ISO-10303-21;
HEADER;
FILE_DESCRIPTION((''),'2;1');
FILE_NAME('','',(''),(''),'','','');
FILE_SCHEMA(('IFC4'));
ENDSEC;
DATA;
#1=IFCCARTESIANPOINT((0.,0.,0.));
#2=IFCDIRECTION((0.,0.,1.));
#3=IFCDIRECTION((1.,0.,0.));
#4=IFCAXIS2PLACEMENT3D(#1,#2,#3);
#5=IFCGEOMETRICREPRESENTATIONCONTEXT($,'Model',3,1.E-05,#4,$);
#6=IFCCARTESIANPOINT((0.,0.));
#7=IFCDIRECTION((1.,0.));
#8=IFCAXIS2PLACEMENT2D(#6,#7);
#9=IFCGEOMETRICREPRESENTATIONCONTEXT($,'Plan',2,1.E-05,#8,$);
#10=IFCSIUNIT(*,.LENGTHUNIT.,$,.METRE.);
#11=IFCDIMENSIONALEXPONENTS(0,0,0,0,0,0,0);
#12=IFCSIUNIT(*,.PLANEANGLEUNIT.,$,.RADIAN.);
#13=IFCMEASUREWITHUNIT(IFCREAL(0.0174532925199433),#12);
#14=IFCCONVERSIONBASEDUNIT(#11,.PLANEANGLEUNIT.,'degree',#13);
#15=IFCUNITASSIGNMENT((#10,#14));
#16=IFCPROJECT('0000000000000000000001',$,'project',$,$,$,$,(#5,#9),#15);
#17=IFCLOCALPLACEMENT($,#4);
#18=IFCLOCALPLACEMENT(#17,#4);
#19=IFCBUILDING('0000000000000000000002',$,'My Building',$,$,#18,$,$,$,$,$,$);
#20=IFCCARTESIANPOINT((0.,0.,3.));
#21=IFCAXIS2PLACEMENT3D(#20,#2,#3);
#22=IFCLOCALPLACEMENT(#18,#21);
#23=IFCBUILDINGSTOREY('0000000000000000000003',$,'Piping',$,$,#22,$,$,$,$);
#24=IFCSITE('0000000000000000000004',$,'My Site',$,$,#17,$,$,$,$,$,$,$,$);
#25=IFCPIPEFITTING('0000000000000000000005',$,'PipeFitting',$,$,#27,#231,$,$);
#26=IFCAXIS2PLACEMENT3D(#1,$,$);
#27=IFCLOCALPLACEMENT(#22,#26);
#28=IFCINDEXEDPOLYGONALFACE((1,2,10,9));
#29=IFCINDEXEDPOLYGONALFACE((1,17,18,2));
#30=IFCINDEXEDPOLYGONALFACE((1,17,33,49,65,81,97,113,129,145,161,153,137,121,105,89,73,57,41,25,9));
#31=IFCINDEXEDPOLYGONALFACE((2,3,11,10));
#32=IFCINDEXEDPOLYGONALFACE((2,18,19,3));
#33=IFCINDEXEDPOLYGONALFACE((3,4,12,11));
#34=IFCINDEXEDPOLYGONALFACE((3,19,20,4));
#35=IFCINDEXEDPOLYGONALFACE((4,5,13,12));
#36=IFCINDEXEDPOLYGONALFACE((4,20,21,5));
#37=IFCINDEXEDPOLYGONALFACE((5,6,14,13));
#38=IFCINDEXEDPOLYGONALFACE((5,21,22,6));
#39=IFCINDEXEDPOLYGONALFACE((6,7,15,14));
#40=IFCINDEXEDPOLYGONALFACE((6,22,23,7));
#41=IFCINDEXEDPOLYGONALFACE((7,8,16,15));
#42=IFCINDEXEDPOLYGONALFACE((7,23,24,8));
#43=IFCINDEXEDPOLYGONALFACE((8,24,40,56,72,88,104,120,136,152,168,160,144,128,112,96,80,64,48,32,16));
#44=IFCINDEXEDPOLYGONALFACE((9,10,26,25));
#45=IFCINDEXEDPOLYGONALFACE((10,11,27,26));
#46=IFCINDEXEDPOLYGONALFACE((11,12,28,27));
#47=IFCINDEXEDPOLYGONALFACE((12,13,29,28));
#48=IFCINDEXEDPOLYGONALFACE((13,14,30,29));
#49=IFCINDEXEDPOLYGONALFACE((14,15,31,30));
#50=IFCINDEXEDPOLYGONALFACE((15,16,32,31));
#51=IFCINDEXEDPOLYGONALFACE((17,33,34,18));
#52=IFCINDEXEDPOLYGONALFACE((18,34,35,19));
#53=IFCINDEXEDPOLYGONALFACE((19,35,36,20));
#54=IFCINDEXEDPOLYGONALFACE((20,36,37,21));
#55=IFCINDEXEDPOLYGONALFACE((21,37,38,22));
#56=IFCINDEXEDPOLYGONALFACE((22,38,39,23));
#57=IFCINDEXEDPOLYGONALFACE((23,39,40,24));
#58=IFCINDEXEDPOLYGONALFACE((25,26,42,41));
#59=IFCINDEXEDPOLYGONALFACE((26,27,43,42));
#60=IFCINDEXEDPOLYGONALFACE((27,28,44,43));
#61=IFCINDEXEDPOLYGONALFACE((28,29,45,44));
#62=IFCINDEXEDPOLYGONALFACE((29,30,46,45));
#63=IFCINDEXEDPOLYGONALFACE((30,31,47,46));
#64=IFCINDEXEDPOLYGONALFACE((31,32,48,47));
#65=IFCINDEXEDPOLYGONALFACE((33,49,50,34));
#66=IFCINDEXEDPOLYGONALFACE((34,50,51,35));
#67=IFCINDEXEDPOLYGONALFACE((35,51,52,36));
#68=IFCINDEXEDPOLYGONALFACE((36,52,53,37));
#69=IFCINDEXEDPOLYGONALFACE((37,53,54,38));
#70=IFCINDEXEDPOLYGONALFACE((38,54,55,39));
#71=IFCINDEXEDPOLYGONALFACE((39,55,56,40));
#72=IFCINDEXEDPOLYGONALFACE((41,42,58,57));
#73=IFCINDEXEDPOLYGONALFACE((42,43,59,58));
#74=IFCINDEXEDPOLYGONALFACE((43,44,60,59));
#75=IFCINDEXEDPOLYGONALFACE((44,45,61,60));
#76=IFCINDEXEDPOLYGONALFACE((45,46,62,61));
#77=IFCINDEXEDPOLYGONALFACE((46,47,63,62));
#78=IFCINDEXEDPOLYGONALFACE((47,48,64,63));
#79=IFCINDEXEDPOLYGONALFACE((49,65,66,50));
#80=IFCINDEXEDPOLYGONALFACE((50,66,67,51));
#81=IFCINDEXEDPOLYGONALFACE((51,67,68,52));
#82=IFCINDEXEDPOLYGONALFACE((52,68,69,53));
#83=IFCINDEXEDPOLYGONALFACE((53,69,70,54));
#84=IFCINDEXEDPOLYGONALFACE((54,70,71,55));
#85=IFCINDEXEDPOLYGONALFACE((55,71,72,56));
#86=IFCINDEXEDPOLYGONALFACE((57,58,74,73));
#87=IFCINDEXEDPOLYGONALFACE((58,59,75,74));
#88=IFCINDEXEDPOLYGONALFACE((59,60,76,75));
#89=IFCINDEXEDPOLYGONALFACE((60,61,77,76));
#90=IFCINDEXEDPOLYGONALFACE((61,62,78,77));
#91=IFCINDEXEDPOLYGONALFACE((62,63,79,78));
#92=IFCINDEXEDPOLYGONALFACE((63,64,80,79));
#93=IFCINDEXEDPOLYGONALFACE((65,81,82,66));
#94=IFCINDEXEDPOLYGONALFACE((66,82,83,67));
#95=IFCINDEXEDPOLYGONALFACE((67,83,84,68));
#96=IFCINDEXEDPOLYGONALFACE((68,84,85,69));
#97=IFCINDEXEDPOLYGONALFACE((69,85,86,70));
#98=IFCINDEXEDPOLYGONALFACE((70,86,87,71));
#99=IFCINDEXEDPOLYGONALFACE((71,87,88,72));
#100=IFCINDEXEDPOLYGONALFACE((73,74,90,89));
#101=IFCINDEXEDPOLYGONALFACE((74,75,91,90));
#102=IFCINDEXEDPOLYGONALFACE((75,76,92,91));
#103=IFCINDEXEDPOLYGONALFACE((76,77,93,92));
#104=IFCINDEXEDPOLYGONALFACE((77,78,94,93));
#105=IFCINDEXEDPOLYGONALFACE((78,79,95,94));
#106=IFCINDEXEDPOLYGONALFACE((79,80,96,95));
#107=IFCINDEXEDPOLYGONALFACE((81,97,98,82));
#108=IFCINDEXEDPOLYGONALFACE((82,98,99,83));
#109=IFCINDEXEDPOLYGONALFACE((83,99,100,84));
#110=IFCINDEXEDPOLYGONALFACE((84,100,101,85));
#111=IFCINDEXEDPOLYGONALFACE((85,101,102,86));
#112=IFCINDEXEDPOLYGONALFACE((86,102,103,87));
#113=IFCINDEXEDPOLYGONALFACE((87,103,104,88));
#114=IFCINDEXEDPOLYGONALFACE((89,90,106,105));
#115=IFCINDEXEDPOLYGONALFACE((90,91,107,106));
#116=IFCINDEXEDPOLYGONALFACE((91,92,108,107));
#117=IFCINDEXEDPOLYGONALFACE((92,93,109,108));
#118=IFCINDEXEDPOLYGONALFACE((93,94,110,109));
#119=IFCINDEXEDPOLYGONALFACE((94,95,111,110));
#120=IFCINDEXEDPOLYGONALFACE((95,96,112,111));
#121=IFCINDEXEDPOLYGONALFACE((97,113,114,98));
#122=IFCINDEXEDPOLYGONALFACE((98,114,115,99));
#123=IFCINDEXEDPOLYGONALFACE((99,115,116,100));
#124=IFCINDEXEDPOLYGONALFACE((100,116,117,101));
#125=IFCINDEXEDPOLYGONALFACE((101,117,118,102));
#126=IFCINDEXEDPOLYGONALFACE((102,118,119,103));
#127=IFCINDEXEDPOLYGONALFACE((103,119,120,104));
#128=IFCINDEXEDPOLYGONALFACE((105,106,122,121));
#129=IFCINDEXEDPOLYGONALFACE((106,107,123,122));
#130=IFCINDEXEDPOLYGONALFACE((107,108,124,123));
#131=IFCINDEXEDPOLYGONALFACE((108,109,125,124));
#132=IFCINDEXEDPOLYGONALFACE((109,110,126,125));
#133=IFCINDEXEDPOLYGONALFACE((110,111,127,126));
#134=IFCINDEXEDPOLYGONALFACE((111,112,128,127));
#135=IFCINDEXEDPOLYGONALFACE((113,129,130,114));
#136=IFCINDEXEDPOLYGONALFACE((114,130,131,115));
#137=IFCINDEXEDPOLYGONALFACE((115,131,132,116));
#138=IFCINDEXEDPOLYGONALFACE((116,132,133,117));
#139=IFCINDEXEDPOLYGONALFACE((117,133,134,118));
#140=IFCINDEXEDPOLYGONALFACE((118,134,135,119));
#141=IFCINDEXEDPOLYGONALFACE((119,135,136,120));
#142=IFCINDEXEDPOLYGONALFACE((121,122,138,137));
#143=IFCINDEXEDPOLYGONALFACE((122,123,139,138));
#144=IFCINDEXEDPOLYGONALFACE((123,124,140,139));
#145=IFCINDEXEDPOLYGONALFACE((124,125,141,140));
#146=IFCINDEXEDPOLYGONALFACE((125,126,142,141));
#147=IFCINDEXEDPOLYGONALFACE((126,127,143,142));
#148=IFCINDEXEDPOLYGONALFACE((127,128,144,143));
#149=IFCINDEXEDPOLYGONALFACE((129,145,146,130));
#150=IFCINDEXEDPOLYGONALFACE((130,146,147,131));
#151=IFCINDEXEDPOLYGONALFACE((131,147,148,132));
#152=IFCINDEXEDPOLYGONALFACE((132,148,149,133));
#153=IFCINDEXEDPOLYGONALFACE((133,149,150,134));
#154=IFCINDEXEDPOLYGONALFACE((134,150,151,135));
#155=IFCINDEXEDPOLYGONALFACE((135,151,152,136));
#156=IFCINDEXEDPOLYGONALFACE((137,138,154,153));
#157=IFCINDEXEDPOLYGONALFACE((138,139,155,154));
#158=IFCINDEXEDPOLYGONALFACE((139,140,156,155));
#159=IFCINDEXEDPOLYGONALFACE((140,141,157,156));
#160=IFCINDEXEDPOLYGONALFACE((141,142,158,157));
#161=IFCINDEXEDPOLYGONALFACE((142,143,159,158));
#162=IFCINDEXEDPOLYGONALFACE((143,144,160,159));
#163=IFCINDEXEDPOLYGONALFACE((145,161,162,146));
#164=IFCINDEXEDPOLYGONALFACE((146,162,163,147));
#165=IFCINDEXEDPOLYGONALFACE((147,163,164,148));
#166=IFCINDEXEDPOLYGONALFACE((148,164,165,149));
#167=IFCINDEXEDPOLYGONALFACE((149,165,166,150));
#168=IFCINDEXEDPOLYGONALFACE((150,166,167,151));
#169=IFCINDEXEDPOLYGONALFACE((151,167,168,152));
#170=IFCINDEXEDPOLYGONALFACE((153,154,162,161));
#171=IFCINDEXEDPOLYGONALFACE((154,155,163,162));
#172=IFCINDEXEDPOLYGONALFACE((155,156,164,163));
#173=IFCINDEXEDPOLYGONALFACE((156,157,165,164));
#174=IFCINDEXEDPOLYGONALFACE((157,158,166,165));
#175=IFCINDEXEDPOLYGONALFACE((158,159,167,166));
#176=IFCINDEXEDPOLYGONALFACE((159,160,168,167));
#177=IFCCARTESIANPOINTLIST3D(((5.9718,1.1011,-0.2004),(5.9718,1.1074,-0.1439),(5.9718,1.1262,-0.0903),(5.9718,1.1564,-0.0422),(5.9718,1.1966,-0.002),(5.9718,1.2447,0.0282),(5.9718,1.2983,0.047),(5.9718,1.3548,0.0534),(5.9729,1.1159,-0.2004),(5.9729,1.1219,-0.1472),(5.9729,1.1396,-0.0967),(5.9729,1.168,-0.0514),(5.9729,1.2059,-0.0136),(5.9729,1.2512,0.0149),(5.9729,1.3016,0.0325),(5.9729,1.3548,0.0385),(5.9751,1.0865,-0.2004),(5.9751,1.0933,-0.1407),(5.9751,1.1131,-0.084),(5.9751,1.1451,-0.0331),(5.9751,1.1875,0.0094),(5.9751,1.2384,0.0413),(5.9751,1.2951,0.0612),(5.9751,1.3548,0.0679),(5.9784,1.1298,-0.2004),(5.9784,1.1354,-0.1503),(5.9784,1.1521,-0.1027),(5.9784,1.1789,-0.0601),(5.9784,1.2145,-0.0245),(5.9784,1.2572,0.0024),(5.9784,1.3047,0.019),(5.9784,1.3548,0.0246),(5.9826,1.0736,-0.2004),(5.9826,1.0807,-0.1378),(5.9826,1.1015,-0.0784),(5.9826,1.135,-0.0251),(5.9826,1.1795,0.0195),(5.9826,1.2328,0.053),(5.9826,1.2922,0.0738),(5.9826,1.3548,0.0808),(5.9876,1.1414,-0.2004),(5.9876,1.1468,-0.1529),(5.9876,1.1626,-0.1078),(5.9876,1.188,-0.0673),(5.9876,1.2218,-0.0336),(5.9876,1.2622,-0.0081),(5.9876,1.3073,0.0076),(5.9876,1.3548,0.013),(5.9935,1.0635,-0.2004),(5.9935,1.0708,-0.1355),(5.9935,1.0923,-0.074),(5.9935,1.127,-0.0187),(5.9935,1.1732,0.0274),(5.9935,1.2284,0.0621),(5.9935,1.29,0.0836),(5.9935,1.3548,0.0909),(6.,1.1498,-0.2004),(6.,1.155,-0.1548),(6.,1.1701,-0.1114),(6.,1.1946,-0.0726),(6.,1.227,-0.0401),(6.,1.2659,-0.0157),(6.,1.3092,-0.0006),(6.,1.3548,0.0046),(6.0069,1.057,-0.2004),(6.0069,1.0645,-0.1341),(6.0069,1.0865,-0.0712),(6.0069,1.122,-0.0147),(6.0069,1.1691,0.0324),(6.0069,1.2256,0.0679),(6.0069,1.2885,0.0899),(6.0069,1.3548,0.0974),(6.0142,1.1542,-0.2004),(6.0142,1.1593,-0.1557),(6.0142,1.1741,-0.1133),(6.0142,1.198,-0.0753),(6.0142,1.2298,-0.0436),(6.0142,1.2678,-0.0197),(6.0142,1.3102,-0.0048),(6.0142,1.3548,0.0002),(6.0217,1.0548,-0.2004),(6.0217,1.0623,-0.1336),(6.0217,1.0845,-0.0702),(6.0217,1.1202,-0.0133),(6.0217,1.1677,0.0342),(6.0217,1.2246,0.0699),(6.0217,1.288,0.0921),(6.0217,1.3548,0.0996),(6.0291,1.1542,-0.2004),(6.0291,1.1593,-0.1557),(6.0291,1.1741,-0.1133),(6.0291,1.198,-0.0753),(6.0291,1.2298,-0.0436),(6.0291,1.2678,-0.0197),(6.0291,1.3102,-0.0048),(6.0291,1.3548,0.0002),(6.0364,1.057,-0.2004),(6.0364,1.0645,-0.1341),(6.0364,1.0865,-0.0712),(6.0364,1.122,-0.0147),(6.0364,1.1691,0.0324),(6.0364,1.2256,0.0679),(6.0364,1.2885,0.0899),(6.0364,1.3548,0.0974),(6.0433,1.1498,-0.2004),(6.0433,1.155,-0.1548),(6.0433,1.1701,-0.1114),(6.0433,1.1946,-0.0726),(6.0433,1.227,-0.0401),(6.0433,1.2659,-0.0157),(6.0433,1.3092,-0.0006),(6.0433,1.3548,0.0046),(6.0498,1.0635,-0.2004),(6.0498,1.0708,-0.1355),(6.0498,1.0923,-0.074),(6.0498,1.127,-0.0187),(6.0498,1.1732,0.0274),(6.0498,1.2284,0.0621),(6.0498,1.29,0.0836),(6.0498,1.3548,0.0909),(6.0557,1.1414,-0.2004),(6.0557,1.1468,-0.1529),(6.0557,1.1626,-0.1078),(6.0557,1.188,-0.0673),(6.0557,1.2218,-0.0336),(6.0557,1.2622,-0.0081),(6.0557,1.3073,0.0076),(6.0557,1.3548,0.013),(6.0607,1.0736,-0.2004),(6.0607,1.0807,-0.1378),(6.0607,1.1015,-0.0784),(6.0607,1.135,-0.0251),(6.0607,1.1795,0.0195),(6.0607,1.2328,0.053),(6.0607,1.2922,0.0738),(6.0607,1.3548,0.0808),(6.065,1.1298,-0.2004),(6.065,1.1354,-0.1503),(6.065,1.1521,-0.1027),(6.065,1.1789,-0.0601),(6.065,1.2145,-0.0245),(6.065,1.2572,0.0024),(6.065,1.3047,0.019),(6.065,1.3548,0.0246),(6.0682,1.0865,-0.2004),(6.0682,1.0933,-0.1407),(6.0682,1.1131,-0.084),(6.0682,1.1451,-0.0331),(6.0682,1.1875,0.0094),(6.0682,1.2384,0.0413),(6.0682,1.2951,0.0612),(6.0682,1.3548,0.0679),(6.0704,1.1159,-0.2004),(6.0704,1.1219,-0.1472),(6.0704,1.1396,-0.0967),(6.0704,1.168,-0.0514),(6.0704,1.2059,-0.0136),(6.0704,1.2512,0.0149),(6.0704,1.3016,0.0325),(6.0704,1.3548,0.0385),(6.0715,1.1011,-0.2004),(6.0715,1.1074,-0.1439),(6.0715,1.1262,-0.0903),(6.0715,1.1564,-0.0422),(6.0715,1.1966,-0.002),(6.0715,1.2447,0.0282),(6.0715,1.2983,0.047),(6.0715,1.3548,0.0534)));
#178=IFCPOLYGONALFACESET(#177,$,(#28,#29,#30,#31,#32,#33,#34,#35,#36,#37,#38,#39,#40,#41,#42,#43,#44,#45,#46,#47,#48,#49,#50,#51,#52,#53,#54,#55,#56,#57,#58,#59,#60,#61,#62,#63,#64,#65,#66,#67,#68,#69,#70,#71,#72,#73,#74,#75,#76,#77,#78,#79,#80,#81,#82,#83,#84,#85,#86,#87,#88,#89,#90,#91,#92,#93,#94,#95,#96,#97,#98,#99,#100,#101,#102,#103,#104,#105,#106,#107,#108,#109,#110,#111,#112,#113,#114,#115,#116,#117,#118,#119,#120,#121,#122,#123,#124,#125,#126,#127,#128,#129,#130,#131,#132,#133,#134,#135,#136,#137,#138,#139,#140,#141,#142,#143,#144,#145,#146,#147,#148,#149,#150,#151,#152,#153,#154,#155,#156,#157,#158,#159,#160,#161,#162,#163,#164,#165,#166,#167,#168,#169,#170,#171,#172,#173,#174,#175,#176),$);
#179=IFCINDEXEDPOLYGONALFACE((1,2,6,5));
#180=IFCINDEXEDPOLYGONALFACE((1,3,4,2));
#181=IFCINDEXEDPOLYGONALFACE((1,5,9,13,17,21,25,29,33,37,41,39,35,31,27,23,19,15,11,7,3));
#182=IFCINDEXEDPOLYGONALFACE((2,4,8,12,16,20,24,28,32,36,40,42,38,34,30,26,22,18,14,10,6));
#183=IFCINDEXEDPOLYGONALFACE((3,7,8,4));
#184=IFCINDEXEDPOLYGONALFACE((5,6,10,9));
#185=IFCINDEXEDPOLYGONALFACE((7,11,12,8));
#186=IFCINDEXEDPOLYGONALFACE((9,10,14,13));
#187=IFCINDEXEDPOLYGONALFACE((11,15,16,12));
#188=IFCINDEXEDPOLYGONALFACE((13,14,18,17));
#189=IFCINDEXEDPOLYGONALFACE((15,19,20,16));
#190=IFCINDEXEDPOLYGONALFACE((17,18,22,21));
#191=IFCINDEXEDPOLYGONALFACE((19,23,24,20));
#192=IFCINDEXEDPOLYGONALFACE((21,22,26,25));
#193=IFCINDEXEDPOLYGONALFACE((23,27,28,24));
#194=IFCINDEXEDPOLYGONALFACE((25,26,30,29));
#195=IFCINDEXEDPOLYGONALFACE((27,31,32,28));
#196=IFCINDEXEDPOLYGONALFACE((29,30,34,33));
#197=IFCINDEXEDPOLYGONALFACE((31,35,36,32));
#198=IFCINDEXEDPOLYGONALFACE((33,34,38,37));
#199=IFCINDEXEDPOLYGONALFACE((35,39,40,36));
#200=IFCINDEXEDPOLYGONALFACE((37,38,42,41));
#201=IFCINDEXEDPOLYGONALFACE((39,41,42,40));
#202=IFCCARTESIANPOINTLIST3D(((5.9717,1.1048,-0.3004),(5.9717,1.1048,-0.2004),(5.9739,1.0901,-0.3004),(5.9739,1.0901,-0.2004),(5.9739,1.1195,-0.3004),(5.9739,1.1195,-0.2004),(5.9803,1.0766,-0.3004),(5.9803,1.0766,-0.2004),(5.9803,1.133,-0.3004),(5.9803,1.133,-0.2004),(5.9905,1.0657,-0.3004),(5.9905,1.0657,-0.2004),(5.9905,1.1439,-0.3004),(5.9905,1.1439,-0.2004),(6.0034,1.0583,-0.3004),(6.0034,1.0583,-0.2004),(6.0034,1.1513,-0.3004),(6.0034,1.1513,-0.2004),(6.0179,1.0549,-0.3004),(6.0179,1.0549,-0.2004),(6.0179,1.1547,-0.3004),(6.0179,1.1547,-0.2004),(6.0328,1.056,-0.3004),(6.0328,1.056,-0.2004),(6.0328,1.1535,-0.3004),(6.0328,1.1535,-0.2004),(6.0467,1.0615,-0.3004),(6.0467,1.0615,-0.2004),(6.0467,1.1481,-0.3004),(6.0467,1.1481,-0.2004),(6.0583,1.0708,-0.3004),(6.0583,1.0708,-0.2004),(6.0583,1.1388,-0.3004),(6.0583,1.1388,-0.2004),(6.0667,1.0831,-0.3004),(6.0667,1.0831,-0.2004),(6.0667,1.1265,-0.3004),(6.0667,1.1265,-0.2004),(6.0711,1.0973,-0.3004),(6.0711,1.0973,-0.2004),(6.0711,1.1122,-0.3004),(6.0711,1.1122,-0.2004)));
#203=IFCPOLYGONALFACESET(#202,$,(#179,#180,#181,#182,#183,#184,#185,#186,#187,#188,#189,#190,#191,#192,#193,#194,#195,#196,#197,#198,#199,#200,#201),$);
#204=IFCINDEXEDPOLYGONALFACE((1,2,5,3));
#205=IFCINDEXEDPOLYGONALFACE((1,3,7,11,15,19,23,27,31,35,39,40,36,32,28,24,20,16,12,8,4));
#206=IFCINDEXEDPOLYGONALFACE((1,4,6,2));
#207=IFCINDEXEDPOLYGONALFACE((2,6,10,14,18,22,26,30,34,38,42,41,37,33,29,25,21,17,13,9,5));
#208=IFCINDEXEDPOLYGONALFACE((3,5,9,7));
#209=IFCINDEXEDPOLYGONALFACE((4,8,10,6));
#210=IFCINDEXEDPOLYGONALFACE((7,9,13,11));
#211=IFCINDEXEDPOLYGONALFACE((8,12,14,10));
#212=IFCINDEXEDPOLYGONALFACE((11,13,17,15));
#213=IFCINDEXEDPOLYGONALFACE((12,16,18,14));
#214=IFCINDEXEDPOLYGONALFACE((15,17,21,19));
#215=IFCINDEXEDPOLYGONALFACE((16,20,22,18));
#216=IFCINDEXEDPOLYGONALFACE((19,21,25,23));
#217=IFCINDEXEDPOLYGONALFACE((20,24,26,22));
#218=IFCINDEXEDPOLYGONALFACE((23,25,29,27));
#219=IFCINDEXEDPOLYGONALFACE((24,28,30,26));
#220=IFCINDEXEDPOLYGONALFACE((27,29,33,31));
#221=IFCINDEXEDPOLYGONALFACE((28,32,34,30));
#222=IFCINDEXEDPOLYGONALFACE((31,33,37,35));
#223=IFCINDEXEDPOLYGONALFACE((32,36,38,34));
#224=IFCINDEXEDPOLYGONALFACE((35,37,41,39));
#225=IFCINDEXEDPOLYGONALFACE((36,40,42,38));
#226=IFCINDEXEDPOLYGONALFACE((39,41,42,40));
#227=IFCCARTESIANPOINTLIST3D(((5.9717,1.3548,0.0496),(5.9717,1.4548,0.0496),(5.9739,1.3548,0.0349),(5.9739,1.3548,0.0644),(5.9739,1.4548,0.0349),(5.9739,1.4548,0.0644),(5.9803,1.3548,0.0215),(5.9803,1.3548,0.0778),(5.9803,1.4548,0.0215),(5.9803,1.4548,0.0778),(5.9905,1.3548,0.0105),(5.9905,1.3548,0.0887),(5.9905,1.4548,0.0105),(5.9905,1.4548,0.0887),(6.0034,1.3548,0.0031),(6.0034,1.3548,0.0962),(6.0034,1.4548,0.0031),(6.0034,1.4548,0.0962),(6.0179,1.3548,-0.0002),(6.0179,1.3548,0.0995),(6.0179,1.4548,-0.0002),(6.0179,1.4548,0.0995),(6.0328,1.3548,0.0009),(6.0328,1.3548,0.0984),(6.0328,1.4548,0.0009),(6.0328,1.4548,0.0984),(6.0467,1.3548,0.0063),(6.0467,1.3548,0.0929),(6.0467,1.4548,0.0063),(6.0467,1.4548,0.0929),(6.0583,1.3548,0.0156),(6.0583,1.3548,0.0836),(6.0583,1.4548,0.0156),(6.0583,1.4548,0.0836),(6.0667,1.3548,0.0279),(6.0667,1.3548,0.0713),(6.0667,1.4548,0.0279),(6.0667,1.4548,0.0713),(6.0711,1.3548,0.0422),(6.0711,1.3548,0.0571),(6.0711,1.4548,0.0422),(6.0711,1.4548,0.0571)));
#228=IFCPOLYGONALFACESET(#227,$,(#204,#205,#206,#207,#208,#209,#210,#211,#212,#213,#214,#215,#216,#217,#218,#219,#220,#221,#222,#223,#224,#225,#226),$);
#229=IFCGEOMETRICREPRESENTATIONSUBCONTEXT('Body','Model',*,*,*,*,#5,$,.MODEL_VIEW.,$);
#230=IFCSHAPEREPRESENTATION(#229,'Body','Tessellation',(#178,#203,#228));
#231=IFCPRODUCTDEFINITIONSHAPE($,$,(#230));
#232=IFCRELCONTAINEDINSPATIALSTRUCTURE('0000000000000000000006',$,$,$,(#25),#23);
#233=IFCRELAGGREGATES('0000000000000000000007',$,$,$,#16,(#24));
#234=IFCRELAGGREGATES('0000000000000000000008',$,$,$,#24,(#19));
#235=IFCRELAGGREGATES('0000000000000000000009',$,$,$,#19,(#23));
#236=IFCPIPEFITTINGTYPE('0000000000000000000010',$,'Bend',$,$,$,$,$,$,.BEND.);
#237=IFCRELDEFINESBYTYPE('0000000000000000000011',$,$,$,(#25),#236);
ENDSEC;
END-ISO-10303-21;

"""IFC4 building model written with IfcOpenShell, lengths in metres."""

from ifc_helpers import new_model, entity, si_unit, converted_unit, frame, origin_with_axes, origin_2d_with_axis, place, context, subcontext, project, spatial, circle, extrude, source, transform, mapped, type_object, type_shapes, element, save


model = new_model("IFC4")

# Units and contexts
model_context = context("Model", 3, precision=1e-05, world=origin_with_axes())
plan_context = context("Plan", 2, precision=1e-05, world=origin_2d_with_axis())
body_context = subcontext(model_context, "Body", "Model", "MODEL_VIEW")
ifc_project = project(units=[si_unit("LENGTHUNIT", "METRE"), converted_unit("PLANEANGLEUNIT", "degree", entity("IfcReal", 0.0174532925199433), si_unit("PLANEANGLEUNIT", "RADIAN"), dimensions=[0, 0, 0, 0, 0, 0, 0])], contexts=[model_context, plan_context])

# Site, building, storey
site_placement = place(None, origin_with_axes())
site = spatial("IfcSite", under=ifc_project, at=site_placement, Name="My Site")
building_placement = place(site_placement, origin_with_axes())
building = spatial("IfcBuilding", under=site, at=building_placement, Name="My Building")
storey_placement = place(building_placement, frame((0.0, 0.0, 3.0), z_axis=(0.0, 0.0, 1.0), x_axis=(1.0, 0.0, 0.0)))
storey = spatial("IfcBuildingStorey", under=building, at=storey_placement, Name="Piping")

# Pipe fitting
pipe_fitting_type = type_object("IfcPipeFittingType", Name="Bend", PredefinedType="BEND")
shared_shape = source(origin_with_axes(), body_context, "Body", "SolidModel", [
    entity("IfcSweptDiskSolid", entity("IfcIndexedPolyCurve", entity("IfcCartesianPointList3D", [[0.0, 0.0, -0.1], [0.0, 0.0732, -0.2768], [0.0, 0.25, -0.35]]), [entity("IfcArcIndex", [1, 2, 3])]), 0.05),
    extrude(circle(Radius=0.05), origin_with_axes(), (0.0, 0.0, -1.0), 0.1),
    extrude(circle(Radius=0.05), frame((0.0, 0.25, -0.35), z_axis=(0.0, 1.0, 0.000007), x_axis=(1.0, 0.0, 0.0)), (0.0, 0.0, 1.0), 0.1),
])
type_shapes(pipe_fitting_type, [shared_shape])
for number, where, z_axis, x_axis, name in (
    (1, (6.0217, 1.1048, -0.3004), (0.0, 0.0, -1.0), (-1.0, 0.0, 0.0), "PipeFitting"),
):
    element("IfcPipeFitting", number, at=place(storey_placement, frame(where, z_axis=z_axis, x_axis=x_axis)), inside=storey, type_object=pipe_fitting_type, Name=name, context=body_context, shape_type="MappedRepresentation", body=[
        mapped(shared_shape, transform((0.0, 0.0, 0.0), x_axis=(1.0, 0.0, 0.0), y_axis=(0.0, 1.0, 0.0), z_axis=(0.0, 0.0, 1.0), scale=1.0)),
    ])

save(model, "model.ifc")
